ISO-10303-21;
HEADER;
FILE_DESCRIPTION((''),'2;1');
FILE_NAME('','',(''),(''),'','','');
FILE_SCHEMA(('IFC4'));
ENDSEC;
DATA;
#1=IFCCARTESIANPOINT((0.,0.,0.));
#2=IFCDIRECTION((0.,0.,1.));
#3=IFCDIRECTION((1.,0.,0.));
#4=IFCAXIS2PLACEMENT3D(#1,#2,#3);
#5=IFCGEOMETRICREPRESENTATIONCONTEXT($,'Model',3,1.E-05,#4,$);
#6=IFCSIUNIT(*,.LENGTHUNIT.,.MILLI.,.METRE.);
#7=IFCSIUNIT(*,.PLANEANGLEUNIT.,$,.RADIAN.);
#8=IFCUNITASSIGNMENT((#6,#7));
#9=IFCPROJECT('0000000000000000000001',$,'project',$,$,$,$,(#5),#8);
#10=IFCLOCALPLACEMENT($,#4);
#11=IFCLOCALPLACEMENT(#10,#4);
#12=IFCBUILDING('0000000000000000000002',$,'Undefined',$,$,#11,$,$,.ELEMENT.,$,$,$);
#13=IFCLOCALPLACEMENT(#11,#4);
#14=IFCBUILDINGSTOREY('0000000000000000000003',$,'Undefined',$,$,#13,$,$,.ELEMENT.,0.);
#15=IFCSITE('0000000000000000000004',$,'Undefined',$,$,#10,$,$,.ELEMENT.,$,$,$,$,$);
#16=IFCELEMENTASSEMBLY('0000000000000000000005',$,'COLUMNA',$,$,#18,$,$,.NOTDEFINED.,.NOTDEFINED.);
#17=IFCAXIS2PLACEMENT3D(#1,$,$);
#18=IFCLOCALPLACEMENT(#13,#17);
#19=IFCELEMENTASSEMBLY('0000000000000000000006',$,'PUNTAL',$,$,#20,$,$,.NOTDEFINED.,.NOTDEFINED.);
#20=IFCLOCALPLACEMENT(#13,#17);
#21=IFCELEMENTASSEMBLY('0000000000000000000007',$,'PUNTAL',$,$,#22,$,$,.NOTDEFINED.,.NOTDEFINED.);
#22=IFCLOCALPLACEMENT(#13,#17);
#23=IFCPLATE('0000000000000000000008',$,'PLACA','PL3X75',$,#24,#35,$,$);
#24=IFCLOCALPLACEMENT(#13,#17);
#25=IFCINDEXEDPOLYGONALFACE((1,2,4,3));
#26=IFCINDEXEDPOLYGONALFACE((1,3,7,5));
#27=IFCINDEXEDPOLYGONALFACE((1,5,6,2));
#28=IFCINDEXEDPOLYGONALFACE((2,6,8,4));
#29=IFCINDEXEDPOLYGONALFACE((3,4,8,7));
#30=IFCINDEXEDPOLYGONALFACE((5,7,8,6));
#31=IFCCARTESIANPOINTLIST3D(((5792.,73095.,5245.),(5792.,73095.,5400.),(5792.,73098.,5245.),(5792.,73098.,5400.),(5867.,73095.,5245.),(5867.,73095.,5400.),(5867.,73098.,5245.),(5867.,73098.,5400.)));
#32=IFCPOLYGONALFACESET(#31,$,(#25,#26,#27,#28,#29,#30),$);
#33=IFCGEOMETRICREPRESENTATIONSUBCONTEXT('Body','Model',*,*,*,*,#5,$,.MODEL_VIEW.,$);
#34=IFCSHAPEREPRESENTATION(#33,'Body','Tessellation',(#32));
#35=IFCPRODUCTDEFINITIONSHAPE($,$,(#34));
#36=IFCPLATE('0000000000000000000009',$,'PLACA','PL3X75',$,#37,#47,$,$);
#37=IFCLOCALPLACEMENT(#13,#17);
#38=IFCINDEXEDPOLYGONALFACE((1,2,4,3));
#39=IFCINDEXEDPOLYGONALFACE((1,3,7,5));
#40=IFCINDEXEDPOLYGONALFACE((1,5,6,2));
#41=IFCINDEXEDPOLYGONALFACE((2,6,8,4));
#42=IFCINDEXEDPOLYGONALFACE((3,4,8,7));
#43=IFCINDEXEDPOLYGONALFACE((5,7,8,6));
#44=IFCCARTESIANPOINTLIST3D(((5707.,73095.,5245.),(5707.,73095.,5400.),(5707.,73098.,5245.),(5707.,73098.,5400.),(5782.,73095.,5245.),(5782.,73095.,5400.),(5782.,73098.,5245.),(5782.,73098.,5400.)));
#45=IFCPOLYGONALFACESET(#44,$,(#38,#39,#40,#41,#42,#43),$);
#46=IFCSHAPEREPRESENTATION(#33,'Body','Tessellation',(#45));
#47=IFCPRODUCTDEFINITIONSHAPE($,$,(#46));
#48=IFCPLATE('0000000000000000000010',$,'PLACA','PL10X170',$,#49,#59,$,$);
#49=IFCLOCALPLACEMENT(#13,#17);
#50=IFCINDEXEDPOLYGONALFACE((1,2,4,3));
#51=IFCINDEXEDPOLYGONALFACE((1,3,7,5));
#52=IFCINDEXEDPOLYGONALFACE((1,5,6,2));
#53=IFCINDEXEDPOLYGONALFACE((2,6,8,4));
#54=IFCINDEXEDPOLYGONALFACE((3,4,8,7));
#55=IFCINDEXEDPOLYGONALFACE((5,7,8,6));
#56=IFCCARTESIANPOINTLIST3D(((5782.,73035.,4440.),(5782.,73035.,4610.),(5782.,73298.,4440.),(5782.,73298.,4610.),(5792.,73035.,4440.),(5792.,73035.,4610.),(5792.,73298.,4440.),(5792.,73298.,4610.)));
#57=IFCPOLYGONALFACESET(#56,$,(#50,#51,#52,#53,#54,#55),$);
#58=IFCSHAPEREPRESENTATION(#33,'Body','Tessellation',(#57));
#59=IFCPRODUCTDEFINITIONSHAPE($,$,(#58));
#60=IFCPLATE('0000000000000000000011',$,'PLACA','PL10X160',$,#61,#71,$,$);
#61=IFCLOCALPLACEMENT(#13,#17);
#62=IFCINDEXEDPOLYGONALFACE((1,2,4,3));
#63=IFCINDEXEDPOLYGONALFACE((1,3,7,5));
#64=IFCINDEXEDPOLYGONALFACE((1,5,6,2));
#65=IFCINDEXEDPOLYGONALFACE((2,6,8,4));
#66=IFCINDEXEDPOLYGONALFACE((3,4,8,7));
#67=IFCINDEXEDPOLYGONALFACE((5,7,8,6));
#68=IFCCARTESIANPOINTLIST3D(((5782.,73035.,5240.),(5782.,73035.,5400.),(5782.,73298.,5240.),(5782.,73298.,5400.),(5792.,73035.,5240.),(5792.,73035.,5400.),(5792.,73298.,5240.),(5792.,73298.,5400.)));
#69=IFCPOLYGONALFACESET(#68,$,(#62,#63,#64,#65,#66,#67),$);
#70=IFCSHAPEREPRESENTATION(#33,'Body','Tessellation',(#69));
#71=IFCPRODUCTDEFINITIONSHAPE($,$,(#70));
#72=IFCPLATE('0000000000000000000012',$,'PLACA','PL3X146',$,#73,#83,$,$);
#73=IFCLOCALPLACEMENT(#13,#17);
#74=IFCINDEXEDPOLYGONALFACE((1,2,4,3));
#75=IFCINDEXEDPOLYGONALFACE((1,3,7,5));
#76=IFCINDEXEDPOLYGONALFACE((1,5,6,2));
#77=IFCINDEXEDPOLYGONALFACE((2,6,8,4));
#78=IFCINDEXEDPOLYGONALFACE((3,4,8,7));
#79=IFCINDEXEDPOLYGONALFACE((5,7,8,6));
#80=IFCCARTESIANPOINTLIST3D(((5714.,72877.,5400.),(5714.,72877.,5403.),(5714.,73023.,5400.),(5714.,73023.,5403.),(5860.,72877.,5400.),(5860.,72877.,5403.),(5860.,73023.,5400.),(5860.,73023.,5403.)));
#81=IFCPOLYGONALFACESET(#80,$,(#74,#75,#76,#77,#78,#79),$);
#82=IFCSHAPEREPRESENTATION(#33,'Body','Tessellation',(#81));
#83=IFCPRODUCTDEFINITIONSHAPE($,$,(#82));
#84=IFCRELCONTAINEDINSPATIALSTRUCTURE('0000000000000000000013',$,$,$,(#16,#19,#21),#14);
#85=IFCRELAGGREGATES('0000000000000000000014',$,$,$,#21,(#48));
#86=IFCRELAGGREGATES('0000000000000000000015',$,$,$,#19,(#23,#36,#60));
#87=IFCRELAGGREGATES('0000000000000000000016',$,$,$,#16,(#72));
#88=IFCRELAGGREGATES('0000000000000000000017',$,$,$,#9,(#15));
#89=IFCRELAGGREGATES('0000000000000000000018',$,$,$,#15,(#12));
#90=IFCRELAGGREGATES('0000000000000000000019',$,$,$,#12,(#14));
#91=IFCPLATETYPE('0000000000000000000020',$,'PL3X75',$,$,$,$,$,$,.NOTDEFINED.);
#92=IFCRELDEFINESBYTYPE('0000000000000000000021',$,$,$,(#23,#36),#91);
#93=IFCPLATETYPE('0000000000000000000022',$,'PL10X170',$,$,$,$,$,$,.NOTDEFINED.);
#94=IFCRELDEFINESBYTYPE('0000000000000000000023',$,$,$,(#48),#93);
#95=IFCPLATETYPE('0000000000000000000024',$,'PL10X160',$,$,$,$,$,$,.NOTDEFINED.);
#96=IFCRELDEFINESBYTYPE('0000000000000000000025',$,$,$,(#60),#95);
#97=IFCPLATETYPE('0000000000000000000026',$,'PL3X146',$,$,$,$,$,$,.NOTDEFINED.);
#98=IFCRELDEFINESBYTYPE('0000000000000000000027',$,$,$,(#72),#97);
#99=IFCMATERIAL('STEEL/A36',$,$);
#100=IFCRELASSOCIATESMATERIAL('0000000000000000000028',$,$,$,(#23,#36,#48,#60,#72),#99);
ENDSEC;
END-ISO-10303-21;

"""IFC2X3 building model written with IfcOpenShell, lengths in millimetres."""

from ifc_helpers import new_model, si_unit, frame, origin_with_axes, place, context, subcontext, project, spatial, polyline, outline, extrude, material, type_object, element, aggregate, save


model = new_model("IFC2X3")

# Units and contexts
model_context = context("Model", 3, precision=1e-05, world=origin_with_axes())
body_context = subcontext(model_context, "Body", "Model", "MODEL_VIEW")
ifc_project = project(units=[si_unit("LENGTHUNIT", "METRE", prefix="MILLI"), si_unit("PLANEANGLEUNIT", "RADIAN")], contexts=[model_context])

# Site, building, storey
site_placement = place(None, origin_with_axes())
site = spatial("IfcSite", under=ifc_project, at=site_placement, Name="Undefined", CompositionType="ELEMENT")
building_placement = place(site_placement, origin_with_axes())
building = spatial("IfcBuilding", under=site, at=building_placement, Name="Undefined", CompositionType="ELEMENT")
storey_placement = place(building_placement, origin_with_axes())
storey = spatial("IfcBuildingStorey", under=building, at=storey_placement, Name="Undefined", CompositionType="ELEMENT", Elevation=0.0)

# Element assemblies
ifc_material_1 = material(Name="STEEL/A36")
assembly_1_placement = place(storey_placement, origin_with_axes())
assembly_1 = element("IfcElementAssembly", 1, at=assembly_1_placement, inside=storey, Name="COLUMNA", AssemblyPlace="NOTDEFINED", PredefinedType="NOTDEFINED")
assembly_2_placement = place(storey_placement, origin_with_axes())
assembly_2 = element("IfcElementAssembly", 2, at=assembly_2_placement, inside=storey, Name="PUNTAL", AssemblyPlace="NOTDEFINED", PredefinedType="NOTDEFINED")
assembly_3_placement = place(storey_placement, origin_with_axes())
assembly_3 = element("IfcElementAssembly", 3, at=assembly_3_placement, inside=storey, Name="PUNTAL", AssemblyPlace="NOTDEFINED", PredefinedType="NOTDEFINED")

# Plates
plate_type_1 = type_object("IfcPlateType", Name="PL3X75", PredefinedType="NOTDEFINED")
plate_1_placement = place(assembly_2_placement, frame((5867.0, 73096.5, 5245.0), z_axis=(0.0, 1.0, 0.0), x_axis=(-1.0, 0.0, 0.0)))
plate_1 = element("IfcPlate", 4, at=plate_1_placement, type_object=plate_type_1, material=ifc_material_1, Name="PLACA", Description="PL3X75", context=body_context, shape_type="SweptSolid", body=[
    extrude(outline(polyline([(0.0, 0.0), (75.0, 0.0), (75.0, 155.0), (0.0, 155.0), (0.0, 0.0)])), frame((0.0, 0.0, -1.5), z_axis=(0.0, 0.0, 1.0), x_axis=(1.0, 0.0, 0.0)), (0.0, 0.0, 1.0), 3.0),
])
plate_2_placement = place(assembly_2_placement, frame((5782.0, 73096.5, 5245.0), z_axis=(0.0, 1.0, 0.0), x_axis=(-1.0, 0.0, 0.0)))
plate_2 = element("IfcPlate", 5, at=plate_2_placement, type_object=plate_type_1, material=ifc_material_1, Name="PLACA", Description="PL3X75", context=body_context, shape_type="SweptSolid", body=[
    extrude(outline(polyline([(0.0, 0.0), (75.0, 0.0), (75.0, 155.0), (0.0, 155.0), (0.0, 0.0)])), frame((0.0, 0.0, -1.5), z_axis=(0.0, 0.0, 1.0), x_axis=(1.0, 0.0, 0.0)), (0.0, 0.0, 1.0), 3.0),
])
plate_type_2 = type_object("IfcPlateType", Name="PL10X170", PredefinedType="NOTDEFINED")
plate_3_placement = place(assembly_3_placement, frame((5787.0, 73035.0, 4525.0), z_axis=(1.0, 0.0, 0.0), x_axis=(0.0, 1.0, 0.0)))
plate_3 = element("IfcPlate", 6, at=plate_3_placement, type_object=plate_type_2, material=ifc_material_1, Name="PLACA", Description="PL10X170", context=body_context, shape_type="SweptSolid", body=[
    extrude(outline(polyline([(0.0, -85.0), (0.0, 85.0), (263.0, 85.0), (263.0, -85.0), (0.0, -85.0)])), frame((0.0, 0.0, -5.0), z_axis=(0.0, 0.0, 1.0), x_axis=(1.0, 0.0, 0.0)), (0.0, 0.0, 1.0), 10.0),
])
aggregate(assembly_3, [plate_3])
plate_type_3 = type_object("IfcPlateType", Name="PL10X160", PredefinedType="NOTDEFINED")
plate_4_placement = place(assembly_2_placement, frame((5787.0, 73035.0, 5320.0), z_axis=(-1.0, 0.0, 0.0), x_axis=(0.0, 1.0, 0.0)))
plate_4 = element("IfcPlate", 7, at=plate_4_placement, type_object=plate_type_3, material=ifc_material_1, Name="PLACA", Description="PL10X160", context=body_context, shape_type="SweptSolid", body=[
    extrude(outline(polyline([(0.0, -80.0), (0.0, 80.0), (263.0, 80.0), (263.0, -80.0), (0.0, -80.0)])), frame((0.0, 0.0, -5.0), z_axis=(0.0, 0.0, 1.0), x_axis=(1.0, 0.0, 0.0)), (0.0, 0.0, 1.0), 10.0),
])
aggregate(assembly_2, [plate_1, plate_2, plate_4])
plate_type_4 = type_object("IfcPlateType", Name="PL3X146", PredefinedType="NOTDEFINED")
plate_5_placement = place(assembly_1_placement, frame((5860.0, 73023.0, 5401.5), z_axis=(0.0, 0.0, -1.0), x_axis=(0.0, -1.0, 0.0)))
plate_5 = element("IfcPlate", 8, at=plate_5_placement, type_object=plate_type_4, material=ifc_material_1, Name="PLACA", Description="PL3X146", context=body_context, shape_type="SweptSolid", body=[
    extrude(outline(polyline([(0.0, 0.0), (146.0, 0.0), (146.0, 146.0), (0.0, 146.0), (0.0, 0.0)])), frame((0.0, 0.0, -1.5), z_axis=(0.0, 0.0, 1.0), x_axis=(1.0, 0.0, 0.0)), (0.0, 0.0, 1.0), 3.0),
])

aggregate(assembly_1, [plate_5])

save(model, "model.ifc")
